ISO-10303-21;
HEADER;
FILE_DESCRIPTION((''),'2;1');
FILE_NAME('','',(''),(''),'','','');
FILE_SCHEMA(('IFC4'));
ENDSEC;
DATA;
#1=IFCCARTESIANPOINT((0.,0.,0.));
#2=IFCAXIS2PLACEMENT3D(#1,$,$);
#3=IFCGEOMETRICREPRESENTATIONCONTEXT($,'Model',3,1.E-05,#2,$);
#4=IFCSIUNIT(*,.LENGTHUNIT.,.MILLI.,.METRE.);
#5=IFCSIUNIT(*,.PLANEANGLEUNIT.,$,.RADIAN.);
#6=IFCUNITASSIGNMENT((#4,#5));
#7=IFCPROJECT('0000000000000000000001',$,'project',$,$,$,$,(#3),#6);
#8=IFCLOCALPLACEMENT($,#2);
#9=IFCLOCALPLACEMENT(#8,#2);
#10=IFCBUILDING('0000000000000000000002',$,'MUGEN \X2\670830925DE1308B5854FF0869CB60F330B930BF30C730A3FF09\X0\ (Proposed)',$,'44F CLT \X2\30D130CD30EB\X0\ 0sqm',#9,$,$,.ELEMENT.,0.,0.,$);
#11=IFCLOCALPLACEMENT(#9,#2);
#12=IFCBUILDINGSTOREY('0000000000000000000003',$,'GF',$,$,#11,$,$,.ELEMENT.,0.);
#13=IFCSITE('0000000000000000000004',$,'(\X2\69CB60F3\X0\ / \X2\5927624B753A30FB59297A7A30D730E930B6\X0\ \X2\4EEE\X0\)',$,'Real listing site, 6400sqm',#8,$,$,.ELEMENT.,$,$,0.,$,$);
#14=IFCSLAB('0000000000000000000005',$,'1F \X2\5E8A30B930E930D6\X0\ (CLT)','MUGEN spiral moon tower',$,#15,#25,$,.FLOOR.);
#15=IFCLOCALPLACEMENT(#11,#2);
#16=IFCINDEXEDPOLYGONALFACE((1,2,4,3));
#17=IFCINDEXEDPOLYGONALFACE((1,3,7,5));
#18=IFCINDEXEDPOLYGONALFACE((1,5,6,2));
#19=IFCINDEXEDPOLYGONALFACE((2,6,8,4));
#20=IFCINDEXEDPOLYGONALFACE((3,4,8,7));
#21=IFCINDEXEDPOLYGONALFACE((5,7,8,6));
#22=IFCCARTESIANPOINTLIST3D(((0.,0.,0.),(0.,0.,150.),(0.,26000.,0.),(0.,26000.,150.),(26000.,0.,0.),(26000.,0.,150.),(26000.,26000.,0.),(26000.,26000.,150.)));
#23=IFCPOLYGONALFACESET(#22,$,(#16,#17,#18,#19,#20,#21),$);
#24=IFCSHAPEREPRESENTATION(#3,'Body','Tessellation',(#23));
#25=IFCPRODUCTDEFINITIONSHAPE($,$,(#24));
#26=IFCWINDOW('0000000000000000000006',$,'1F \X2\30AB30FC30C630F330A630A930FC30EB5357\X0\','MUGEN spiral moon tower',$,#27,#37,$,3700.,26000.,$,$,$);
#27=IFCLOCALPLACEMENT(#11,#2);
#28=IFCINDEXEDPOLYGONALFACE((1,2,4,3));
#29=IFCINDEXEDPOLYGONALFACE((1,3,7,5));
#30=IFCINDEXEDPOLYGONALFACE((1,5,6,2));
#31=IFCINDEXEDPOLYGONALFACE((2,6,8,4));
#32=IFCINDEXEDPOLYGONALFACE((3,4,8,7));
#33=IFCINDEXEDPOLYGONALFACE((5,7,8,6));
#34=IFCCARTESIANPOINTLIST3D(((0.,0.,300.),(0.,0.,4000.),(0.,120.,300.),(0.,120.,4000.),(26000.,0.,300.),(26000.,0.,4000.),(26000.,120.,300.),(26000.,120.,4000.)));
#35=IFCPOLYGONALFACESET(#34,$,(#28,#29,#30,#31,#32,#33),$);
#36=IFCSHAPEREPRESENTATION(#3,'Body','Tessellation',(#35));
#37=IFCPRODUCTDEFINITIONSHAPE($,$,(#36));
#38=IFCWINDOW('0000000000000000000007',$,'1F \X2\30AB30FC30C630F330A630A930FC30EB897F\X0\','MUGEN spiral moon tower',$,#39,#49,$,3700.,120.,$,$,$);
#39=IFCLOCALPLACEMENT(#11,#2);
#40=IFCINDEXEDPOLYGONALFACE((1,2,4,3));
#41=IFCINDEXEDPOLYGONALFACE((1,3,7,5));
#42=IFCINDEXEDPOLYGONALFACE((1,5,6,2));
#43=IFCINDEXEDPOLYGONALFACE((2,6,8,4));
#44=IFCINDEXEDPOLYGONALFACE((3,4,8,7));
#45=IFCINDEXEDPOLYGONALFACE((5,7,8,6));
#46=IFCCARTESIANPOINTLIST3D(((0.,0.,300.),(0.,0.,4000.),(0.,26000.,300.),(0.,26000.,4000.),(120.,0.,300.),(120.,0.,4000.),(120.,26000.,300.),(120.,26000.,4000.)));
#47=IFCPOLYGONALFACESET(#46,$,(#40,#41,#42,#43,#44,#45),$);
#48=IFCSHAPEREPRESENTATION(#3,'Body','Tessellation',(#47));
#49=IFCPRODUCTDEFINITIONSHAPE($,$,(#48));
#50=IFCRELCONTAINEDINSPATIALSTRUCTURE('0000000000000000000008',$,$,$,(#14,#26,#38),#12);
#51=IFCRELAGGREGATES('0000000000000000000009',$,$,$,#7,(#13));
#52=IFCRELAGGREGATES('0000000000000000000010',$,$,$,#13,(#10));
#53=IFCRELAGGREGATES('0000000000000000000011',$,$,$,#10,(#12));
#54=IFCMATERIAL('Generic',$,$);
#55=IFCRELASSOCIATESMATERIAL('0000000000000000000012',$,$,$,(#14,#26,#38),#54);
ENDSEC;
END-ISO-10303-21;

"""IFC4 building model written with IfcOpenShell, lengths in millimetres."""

from ifc_helpers import new_model, si_unit, frame, frame_2d, origin, place, context, project, spatial, rectangle, extrude, material, element, save


model = new_model("IFC4")

# Units and contexts
model_context = context("Model", 3, precision=1e-05, world=origin())
ifc_project = project(units=[si_unit("LENGTHUNIT", "METRE", prefix="MILLI"), si_unit("PLANEANGLEUNIT", "RADIAN")], contexts=[model_context])

# Site, building, storey
site_placement = place(None, origin())
site = spatial("IfcSite", under=ifc_project, at=site_placement, Name="(構想 / 大手町・天空プラザ 仮)", ObjectType="Real listing site, 6400sqm", CompositionType="ELEMENT", RefElevation=0.0)
building_placement = place(site_placement, origin())
building = spatial("IfcBuilding", under=site, at=building_placement, Name="MUGEN 月を巡る塔（構想スタディ） (Proposed)", ObjectType="44F CLT パネル 0sqm", CompositionType="ELEMENT", ElevationOfRefHeight=0.0, ElevationOfTerrain=0.0)
storey_placement = place(building_placement, origin())
storey = spatial("IfcBuildingStorey", under=building, at=storey_placement, Name="GF", CompositionType="ELEMENT", Elevation=0.0)

# Slab
ifc_material = material(Name="Generic")
slab_1_placement = place(storey_placement, origin())
element("IfcSlab", 1, at=slab_1_placement, inside=storey, material=ifc_material, Name="1F 床スラブ (CLT)", Description="MUGEN spiral moon tower", PredefinedType="FLOOR", context=model_context, shape_type="SweptSolid", body=[
    extrude(rectangle(XDim=26000.0, YDim=26000.0, at=frame_2d((13000.0, 13000.0))), origin(), (0.0, 0.0, 1.0), 150.0),
])

# Windows
window_1_placement = place(storey_placement, frame((0.0, 0.0, 150.0)))
element("IfcWindow", 2, at=window_1_placement, inside=storey, material=ifc_material, Name="1F カーテンウォール南", Description="MUGEN spiral moon tower", OverallHeight=3700.0, OverallWidth=26000.0, context=model_context, shape_type="SweptSolid", body=[
    extrude(rectangle(XDim=26000.0, YDim=120.0, at=frame_2d((13000.0, 60.0))), frame((0.0, 0.0, 150.0)), (0.0, 0.0, 1.0), 3700.0),
])
window_2_placement = place(storey_placement, frame((0.0, 0.0, 150.0)))
element("IfcWindow", 3, at=window_2_placement, inside=storey, material=ifc_material, Name="1F カーテンウォール西", Description="MUGEN spiral moon tower", OverallHeight=3700.0, OverallWidth=120.0, context=model_context, shape_type="SweptSolid", body=[
    extrude(rectangle(XDim=120.0, YDim=26000.0, at=frame_2d((60.0, 13000.0))), frame((0.0, 0.0, 150.0)), (0.0, 0.0, 1.0), 3700.0),
])

save(model, "model.ifc")
